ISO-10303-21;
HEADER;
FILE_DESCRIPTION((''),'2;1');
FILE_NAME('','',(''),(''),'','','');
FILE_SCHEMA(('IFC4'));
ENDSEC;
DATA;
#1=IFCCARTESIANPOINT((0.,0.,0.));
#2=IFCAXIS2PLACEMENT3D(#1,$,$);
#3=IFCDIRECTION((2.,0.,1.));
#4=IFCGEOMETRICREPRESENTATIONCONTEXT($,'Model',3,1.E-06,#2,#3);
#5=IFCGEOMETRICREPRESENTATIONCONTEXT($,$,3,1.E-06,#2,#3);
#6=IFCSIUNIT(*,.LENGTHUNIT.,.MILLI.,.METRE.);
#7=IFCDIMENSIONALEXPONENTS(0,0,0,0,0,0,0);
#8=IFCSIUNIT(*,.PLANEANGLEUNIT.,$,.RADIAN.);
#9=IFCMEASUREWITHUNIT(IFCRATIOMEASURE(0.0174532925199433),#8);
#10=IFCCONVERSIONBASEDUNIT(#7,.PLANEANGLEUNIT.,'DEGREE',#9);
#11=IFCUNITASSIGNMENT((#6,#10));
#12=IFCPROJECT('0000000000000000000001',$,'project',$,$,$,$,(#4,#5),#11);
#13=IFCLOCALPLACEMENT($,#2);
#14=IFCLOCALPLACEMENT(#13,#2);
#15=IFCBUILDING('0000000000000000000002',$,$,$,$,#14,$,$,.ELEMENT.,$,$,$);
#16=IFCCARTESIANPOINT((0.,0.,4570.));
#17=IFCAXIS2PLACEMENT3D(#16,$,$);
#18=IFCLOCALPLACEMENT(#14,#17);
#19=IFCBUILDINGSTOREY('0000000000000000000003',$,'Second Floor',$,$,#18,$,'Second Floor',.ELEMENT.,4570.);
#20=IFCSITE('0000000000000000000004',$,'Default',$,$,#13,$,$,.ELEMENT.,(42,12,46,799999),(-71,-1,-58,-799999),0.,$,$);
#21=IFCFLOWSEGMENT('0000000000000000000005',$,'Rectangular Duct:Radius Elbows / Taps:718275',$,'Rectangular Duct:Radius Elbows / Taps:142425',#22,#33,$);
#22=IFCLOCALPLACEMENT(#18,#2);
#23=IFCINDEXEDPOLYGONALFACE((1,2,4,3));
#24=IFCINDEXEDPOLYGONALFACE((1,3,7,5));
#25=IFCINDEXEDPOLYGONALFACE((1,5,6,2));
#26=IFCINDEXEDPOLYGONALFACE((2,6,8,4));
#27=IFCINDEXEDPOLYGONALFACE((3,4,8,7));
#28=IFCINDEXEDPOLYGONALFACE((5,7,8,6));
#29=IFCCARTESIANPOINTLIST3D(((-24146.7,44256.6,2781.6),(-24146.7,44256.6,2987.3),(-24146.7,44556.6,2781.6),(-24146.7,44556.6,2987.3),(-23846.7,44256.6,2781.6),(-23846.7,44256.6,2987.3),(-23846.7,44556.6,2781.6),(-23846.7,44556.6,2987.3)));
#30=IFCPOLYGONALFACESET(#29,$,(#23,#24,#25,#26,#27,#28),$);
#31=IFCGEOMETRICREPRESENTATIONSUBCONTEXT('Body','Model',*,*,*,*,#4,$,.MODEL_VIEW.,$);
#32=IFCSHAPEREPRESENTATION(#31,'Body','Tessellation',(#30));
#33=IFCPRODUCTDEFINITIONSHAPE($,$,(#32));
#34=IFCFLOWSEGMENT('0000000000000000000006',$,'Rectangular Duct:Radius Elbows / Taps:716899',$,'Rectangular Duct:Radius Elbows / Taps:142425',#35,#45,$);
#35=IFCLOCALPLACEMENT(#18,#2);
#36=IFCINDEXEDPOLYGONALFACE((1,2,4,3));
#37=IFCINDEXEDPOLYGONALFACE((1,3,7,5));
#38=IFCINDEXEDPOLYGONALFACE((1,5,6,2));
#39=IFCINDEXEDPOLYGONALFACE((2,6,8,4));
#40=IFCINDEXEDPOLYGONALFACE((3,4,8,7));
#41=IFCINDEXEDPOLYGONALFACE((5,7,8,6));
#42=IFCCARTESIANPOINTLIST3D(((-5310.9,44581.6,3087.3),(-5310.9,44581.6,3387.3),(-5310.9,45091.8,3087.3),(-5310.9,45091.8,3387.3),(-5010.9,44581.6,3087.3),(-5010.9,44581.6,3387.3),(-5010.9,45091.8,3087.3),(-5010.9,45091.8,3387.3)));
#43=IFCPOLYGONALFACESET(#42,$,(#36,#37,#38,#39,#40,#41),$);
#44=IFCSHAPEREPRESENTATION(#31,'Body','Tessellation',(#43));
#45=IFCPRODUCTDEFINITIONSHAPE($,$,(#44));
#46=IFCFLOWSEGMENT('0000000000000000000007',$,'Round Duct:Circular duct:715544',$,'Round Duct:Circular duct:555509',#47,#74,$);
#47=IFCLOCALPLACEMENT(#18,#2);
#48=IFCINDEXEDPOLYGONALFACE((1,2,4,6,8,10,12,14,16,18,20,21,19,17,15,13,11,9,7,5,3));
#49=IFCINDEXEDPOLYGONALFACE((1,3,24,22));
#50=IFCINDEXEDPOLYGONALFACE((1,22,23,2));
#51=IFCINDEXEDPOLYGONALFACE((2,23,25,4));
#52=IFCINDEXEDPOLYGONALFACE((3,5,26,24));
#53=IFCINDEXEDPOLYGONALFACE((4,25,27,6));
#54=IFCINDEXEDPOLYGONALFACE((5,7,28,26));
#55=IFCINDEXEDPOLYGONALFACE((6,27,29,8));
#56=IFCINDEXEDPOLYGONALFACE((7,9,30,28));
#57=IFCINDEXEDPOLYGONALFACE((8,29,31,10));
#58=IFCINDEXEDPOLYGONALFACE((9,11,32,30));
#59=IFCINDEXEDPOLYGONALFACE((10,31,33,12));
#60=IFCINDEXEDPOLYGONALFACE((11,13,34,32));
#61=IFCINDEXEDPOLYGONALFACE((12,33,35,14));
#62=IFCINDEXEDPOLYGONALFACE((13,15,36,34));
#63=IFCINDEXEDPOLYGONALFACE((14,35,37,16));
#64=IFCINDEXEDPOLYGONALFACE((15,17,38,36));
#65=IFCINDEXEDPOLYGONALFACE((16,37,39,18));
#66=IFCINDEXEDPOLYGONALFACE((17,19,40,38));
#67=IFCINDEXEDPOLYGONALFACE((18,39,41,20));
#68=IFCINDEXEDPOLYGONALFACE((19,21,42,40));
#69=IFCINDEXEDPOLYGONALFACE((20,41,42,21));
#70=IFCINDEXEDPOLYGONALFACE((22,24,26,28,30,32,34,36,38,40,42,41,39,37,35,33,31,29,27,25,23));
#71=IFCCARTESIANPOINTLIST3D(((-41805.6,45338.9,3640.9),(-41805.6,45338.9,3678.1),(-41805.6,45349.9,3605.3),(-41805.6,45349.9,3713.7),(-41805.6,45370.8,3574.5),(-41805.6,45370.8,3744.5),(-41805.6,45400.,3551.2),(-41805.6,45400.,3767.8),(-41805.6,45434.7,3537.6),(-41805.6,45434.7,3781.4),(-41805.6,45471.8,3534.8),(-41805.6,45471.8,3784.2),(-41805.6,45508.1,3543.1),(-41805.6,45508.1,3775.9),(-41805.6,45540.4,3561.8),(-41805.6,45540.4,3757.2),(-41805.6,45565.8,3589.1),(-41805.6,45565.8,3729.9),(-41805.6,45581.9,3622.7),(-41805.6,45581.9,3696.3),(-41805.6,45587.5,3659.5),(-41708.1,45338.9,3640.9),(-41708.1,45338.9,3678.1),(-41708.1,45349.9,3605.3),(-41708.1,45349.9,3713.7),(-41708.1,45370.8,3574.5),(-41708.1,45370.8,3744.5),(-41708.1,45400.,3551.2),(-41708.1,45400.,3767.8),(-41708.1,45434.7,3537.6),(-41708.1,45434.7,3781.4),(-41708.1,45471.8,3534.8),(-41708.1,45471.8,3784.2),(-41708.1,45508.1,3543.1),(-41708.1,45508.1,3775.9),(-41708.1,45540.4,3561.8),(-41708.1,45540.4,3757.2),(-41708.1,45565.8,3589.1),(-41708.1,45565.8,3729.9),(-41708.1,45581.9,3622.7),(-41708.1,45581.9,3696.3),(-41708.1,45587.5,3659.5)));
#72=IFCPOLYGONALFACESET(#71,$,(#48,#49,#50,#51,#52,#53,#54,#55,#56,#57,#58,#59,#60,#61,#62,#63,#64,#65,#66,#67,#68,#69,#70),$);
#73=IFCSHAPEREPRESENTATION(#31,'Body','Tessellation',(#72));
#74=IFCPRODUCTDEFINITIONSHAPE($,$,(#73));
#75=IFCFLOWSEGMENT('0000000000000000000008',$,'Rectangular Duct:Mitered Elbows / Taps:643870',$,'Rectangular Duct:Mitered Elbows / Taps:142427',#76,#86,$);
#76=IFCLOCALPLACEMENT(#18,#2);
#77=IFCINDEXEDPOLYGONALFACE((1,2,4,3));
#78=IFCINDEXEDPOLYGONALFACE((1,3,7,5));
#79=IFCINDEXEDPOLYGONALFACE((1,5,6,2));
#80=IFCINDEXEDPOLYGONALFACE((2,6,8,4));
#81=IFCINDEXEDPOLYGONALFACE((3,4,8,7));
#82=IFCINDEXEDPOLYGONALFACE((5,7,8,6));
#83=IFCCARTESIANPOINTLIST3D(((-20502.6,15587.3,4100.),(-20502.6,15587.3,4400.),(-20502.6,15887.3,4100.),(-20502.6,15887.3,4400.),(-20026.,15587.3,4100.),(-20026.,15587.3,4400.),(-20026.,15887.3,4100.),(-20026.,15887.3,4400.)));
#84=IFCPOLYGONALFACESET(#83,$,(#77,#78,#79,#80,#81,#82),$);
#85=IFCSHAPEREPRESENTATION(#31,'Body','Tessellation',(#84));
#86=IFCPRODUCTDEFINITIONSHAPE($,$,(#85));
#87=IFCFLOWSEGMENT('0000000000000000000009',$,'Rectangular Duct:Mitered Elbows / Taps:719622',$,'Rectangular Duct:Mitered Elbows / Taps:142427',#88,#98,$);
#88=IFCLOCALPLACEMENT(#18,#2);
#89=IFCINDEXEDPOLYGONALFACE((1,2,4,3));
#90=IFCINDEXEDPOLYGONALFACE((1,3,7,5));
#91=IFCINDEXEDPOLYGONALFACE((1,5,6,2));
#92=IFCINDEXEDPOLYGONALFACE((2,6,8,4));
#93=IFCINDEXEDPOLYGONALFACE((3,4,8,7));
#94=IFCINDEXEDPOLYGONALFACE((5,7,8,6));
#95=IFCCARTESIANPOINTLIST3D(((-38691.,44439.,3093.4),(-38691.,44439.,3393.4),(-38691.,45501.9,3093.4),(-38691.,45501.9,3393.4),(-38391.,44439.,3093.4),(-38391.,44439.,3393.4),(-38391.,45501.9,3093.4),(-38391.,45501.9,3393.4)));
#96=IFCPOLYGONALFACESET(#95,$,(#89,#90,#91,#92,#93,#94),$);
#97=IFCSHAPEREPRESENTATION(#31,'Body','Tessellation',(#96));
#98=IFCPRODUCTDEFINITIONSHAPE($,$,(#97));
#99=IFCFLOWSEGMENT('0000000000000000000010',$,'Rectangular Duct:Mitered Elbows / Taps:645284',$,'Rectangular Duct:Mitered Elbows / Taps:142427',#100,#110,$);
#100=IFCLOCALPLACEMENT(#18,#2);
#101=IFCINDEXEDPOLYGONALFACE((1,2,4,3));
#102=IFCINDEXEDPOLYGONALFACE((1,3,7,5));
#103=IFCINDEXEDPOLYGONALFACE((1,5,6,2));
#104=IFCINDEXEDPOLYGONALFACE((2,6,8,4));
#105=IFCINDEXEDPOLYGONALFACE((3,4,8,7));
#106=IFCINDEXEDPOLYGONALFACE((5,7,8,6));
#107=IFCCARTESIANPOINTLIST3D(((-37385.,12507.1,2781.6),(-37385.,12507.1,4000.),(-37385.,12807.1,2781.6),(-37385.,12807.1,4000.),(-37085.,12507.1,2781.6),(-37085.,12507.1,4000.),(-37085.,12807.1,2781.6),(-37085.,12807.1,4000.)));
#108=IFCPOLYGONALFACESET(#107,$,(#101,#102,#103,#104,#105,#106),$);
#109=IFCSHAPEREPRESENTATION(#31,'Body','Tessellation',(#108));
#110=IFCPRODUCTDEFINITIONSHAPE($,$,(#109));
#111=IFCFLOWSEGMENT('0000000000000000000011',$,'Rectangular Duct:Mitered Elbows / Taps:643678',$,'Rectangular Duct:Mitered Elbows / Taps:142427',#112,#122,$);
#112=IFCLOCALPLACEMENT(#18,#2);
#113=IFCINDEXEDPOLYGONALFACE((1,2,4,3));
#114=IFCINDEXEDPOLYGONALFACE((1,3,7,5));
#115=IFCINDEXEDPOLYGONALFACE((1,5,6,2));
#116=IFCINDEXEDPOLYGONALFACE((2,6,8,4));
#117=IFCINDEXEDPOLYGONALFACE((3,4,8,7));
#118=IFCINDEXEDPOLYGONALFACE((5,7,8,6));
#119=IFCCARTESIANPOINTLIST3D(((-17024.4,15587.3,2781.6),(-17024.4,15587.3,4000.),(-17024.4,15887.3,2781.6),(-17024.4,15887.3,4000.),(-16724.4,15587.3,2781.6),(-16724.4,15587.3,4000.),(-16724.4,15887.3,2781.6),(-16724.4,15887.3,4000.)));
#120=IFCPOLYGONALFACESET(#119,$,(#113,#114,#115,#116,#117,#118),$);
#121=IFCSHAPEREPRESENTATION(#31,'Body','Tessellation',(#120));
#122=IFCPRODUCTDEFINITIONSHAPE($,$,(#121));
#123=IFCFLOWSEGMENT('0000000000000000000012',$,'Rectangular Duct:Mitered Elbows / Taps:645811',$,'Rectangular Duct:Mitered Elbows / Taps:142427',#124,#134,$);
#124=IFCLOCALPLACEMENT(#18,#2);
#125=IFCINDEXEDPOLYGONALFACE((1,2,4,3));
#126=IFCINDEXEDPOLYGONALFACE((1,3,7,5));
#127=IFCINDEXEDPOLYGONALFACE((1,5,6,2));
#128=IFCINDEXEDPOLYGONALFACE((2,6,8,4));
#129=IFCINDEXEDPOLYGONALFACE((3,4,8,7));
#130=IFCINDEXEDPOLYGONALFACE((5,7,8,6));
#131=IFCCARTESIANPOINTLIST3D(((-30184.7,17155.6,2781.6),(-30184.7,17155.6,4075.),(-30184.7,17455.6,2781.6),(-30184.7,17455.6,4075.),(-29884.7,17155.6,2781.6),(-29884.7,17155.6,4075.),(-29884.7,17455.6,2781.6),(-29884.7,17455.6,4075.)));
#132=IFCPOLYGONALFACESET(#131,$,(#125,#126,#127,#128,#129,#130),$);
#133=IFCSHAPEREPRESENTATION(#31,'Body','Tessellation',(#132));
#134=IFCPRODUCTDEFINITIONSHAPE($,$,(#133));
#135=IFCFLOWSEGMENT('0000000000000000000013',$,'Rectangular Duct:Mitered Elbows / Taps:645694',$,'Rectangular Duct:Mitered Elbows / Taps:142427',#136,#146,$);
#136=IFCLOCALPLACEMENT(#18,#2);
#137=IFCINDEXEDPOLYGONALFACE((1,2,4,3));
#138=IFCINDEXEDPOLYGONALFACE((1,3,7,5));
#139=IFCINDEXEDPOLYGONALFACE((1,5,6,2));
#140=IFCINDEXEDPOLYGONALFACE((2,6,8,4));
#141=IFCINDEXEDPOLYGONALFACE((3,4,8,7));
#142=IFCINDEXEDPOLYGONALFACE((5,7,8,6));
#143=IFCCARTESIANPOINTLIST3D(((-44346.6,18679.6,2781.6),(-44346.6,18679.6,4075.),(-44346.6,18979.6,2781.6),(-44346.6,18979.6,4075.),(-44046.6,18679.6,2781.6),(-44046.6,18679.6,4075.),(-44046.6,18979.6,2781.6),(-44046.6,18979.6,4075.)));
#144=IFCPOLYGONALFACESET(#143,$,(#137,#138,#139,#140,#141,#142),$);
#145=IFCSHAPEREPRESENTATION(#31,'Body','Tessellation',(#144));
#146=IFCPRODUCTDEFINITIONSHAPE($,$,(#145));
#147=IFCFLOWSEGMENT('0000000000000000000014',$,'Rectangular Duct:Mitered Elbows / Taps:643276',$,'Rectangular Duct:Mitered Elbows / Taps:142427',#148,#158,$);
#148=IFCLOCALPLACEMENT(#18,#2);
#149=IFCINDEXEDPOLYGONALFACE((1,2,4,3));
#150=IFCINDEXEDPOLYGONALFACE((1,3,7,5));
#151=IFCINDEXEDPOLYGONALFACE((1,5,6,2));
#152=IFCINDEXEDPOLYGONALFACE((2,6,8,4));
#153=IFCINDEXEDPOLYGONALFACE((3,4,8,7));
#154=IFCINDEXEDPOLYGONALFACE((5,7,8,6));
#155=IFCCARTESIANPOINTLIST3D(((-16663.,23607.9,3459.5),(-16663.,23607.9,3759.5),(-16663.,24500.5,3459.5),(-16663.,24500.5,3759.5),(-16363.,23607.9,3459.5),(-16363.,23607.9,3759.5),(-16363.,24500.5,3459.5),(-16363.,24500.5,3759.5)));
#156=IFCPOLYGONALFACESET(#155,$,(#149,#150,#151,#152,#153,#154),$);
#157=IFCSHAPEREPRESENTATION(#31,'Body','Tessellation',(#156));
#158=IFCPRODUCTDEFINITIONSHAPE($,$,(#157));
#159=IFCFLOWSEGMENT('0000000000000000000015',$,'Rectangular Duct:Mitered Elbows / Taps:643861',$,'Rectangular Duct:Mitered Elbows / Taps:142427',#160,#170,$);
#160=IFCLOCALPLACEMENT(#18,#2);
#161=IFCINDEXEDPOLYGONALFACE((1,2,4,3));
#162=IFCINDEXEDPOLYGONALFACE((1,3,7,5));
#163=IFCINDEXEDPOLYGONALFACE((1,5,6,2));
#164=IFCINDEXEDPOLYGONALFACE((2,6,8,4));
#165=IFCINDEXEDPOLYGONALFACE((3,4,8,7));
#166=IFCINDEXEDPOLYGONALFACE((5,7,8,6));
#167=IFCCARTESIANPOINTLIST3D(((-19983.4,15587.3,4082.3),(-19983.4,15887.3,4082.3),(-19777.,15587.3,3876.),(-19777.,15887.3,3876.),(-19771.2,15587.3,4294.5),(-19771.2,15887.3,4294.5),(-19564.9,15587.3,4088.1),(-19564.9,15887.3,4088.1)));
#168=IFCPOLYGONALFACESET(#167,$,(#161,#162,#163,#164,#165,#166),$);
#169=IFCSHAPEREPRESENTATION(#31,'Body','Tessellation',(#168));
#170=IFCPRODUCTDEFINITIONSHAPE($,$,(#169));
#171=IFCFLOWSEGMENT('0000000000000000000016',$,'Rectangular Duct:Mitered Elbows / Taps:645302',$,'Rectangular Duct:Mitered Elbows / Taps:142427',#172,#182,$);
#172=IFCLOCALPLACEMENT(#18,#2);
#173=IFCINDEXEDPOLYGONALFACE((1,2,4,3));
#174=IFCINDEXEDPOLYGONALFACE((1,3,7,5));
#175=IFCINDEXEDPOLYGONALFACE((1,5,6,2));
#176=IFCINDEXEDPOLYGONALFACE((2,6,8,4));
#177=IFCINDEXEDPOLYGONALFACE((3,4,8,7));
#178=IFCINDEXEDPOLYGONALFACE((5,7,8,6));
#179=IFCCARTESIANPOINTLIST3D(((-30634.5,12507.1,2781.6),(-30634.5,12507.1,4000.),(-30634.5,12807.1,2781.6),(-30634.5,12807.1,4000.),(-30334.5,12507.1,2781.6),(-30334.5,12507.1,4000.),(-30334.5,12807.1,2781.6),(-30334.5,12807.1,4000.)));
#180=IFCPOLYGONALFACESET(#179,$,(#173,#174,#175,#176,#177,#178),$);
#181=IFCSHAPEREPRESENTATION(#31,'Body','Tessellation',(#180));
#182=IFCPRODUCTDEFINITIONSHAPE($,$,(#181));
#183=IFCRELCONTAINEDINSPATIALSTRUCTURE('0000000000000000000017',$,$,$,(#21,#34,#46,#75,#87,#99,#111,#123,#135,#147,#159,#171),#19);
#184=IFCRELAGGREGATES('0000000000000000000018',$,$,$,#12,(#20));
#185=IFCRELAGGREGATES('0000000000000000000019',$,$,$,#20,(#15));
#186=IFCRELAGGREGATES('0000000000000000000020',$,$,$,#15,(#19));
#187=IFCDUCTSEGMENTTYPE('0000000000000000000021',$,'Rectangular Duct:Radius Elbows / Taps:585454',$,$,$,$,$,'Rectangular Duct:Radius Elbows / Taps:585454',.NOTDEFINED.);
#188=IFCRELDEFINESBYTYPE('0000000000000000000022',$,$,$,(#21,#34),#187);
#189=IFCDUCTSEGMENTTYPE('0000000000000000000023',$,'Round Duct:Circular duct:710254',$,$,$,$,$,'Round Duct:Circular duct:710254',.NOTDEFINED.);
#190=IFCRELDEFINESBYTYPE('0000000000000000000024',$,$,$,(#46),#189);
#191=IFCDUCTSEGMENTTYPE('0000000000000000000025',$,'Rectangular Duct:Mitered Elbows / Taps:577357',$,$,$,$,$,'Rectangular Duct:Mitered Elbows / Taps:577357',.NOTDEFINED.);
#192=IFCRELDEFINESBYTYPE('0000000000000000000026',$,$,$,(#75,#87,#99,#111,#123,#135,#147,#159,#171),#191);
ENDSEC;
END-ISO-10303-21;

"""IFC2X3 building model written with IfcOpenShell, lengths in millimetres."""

from ifc_helpers import new_model, entity, si_unit, converted_unit, direction, frame, frame_2d, origin, origin_2d_with_axis, place, context, subcontext, project, spatial, rectangle, circle, extrude, type_object, element, save


model = new_model("IFC2X3")

# Units and contexts
model_context = context("Model", 3, precision=1e-06, world=origin(), true_north=direction((2.0, 0.0, 1.0)))
context_of_model = context(None, 3, precision=1e-06, world=origin(), true_north=direction((2.0, 0.0, 1.0)))
body_context = subcontext(model_context, "Body", "Model", "MODEL_VIEW")
ifc_project = project(units=[si_unit("LENGTHUNIT", "METRE", prefix="MILLI"), converted_unit("PLANEANGLEUNIT", "DEGREE", entity("IfcRatioMeasure", 0.0174532925199433), si_unit("PLANEANGLEUNIT", "RADIAN"), dimensions=[0, 0, 0, 0, 0, 0, 0])], contexts=[model_context, context_of_model])

# Site, building, storey
site_placement = place(None, origin())
site = spatial("IfcSite", under=ifc_project, at=site_placement, Name="Default", CompositionType="ELEMENT", RefLatitude=(42, 12, 46, 799999), RefLongitude=(-71, -1, -58, -799999), RefElevation=0.0)
building_placement = place(site_placement, origin())
building = spatial("IfcBuilding", under=site, at=building_placement, CompositionType="ELEMENT")
storey_placement = place(building_placement, frame((0.0, 0.0, 4570.0)))
storey = spatial("IfcBuildingStorey", under=building, at=storey_placement, Name="Second Floor", LongName="Second Floor", CompositionType="ELEMENT", Elevation=4570.0)

# Flow segments
duct_segment_type_1 = type_object("IfcDuctSegmentType", Name="Rectangular Duct:Radius Elbows / Taps:585454", ElementType="Rectangular Duct:Radius Elbows / Taps:585454", PredefinedType="NOTDEFINED")
flow_segment_1_placement = place(storey_placement, origin())
element("IfcFlowSegment", 1, at=flow_segment_1_placement, inside=storey, type_object=duct_segment_type_1, Name="Rectangular Duct:Radius Elbows / Taps:718275", ObjectType="Rectangular Duct:Radius Elbows / Taps:142425", context=body_context, shape_type="SweptSolid", body=[
    extrude(rectangle(XDim=300.0, YDim=300.0, at=origin_2d_with_axis()), frame((-23996.7, 44406.6, 2781.6), z_axis=(0.0, 0.0, 1.0), x_axis=(-1.0, 0.0, 0.0)), (0.0, 0.0, 1.0), 205.7),
])
flow_segment_2_placement = place(storey_placement, origin())
element("IfcFlowSegment", 2, at=flow_segment_2_placement, inside=storey, type_object=duct_segment_type_1, Name="Rectangular Duct:Radius Elbows / Taps:716899", ObjectType="Rectangular Duct:Radius Elbows / Taps:142425", context=body_context, shape_type="SweptSolid", body=[
    extrude(rectangle(XDim=510.1, YDim=300.0, at=frame_2d((0.0, 0.0), x_axis=(1.0, 0.0))), frame((-5160.9, 44836.7, 3087.3), z_axis=(0.0, 0.0, 1.0), x_axis=(0.0, -1.0, 0.0)), (0.0, 0.0, 1.0), 300.0),
])
duct_segment_type_2 = type_object("IfcDuctSegmentType", Name="Round Duct:Circular duct:710254", ElementType="Round Duct:Circular duct:710254", PredefinedType="NOTDEFINED")
flow_segment_3_placement = place(storey_placement, origin())
element("IfcFlowSegment", 3, at=flow_segment_3_placement, inside=storey, type_object=duct_segment_type_2, Name="Round Duct:Circular duct:715544", ObjectType="Round Duct:Circular duct:555509", context=body_context, shape_type="SweptSolid", body=[
    extrude(circle(Radius=125.0, at=origin_2d_with_axis()), frame((-41805.6, 45462.5, 3659.5), z_axis=(1.0, 0.0, 0.0), x_axis=(0.0, 1.0, 0.0)), (0.0, 0.0, 1.0), 97.5),
])
duct_segment_type_3 = type_object("IfcDuctSegmentType", Name="Rectangular Duct:Mitered Elbows / Taps:577357", ElementType="Rectangular Duct:Mitered Elbows / Taps:577357", PredefinedType="NOTDEFINED")
flow_segment_4_placement = place(storey_placement, origin())
element("IfcFlowSegment", 4, at=flow_segment_4_placement, inside=storey, type_object=duct_segment_type_3, Name="Rectangular Duct:Mitered Elbows / Taps:643870", ObjectType="Rectangular Duct:Mitered Elbows / Taps:142427", context=body_context, shape_type="SweptSolid", body=[
    extrude(rectangle(XDim=476.6, YDim=300.0, at=frame_2d((0.0, 0.0), x_axis=(1.0, 0.0))), frame((-20264.3, 15737.3, 4100.0), z_axis=(0.0, 0.0, 1.0), x_axis=(-1.0, 0.0, 0.0)), (0.0, 0.0, 1.0), 300.0),
])
flow_segment_5_placement = place(storey_placement, origin())
element("IfcFlowSegment", 5, at=flow_segment_5_placement, inside=storey, type_object=duct_segment_type_3, Name="Rectangular Duct:Mitered Elbows / Taps:719622", ObjectType="Rectangular Duct:Mitered Elbows / Taps:142427", context=body_context, shape_type="SweptSolid", body=[
    extrude(rectangle(XDim=1062.8, YDim=300.0, at=frame_2d((0.0, 0.0), x_axis=(1.0, 0.0))), frame((-38541.0, 44970.5, 3093.4), z_axis=(0.0, 0.0, 1.0), x_axis=(0.0, 1.0, 0.0)), (0.0, 0.0, 1.0), 300.0),
])
flow_segment_6_placement = place(storey_placement, origin())
element("IfcFlowSegment", 6, at=flow_segment_6_placement, inside=storey, type_object=duct_segment_type_3, Name="Rectangular Duct:Mitered Elbows / Taps:645284", ObjectType="Rectangular Duct:Mitered Elbows / Taps:142427", context=body_context, shape_type="SweptSolid", body=[
    extrude(rectangle(XDim=300.0, YDim=300.0, at=origin_2d_with_axis()), frame((-37235.0, 12657.1, 2781.6)), (0.0, 0.0, 1.0), 1218.4),
])
flow_segment_7_placement = place(storey_placement, origin())
element("IfcFlowSegment", 7, at=flow_segment_7_placement, inside=storey, type_object=duct_segment_type_3, Name="Rectangular Duct:Mitered Elbows / Taps:643678", ObjectType="Rectangular Duct:Mitered Elbows / Taps:142427", context=body_context, shape_type="SweptSolid", body=[
    extrude(rectangle(XDim=300.0, YDim=300.0, at=origin_2d_with_axis()), frame((-16874.4, 15737.3, 2781.6)), (0.0, 0.0, 1.0), 1218.4),
])
flow_segment_8_placement = place(storey_placement, origin())
element("IfcFlowSegment", 8, at=flow_segment_8_placement, inside=storey, type_object=duct_segment_type_3, Name="Rectangular Duct:Mitered Elbows / Taps:645811", ObjectType="Rectangular Duct:Mitered Elbows / Taps:142427", context=body_context, shape_type="SweptSolid", body=[
    extrude(rectangle(XDim=300.0, YDim=300.0, at=frame_2d((0.0, 0.0), x_axis=(1.0, 0.0))), frame((-30034.7, 17305.6, 2781.6)), (0.0, 0.0, 1.0), 1293.4),
])
flow_segment_9_placement = place(storey_placement, origin())
element("IfcFlowSegment", 9, at=flow_segment_9_placement, inside=storey, type_object=duct_segment_type_3, Name="Rectangular Duct:Mitered Elbows / Taps:645694", ObjectType="Rectangular Duct:Mitered Elbows / Taps:142427", context=body_context, shape_type="SweptSolid", body=[
    extrude(rectangle(XDim=300.0, YDim=300.0, at=origin_2d_with_axis()), frame((-44196.6, 18829.6, 2781.6), z_axis=(0.0, 0.0, 1.0), x_axis=(-1.0, 0.0, 0.0)), (0.0, 0.0, 1.0), 1293.4),
])
flow_segment_10_placement = place(storey_placement, origin())
element("IfcFlowSegment", 10, at=flow_segment_10_placement, inside=storey, type_object=duct_segment_type_3, Name="Rectangular Duct:Mitered Elbows / Taps:643276", ObjectType="Rectangular Duct:Mitered Elbows / Taps:142427", context=body_context, shape_type="SweptSolid", body=[
    extrude(rectangle(XDim=892.6, YDim=300.0, at=origin_2d_with_axis()), frame((-16513.0, 24054.2, 3459.5), z_axis=(0.0, 0.0, 1.0), x_axis=(0.0, 1.0, 0.0)), (0.0, 0.0, 1.0), 300.0),
])
flow_segment_11_placement = place(storey_placement, origin())
element("IfcFlowSegment", 11, at=flow_segment_11_placement, inside=storey, type_object=duct_segment_type_3, Name="Rectangular Duct:Mitered Elbows / Taps:643861", ObjectType="Rectangular Duct:Mitered Elbows / Taps:142427", context=body_context, shape_type="SweptSolid", body=[
    extrude(rectangle(XDim=291.8, YDim=300.0, at=frame_2d((0.0, 0.0), x_axis=(1.0, 0.0))), frame((-19774.1, 15587.3, 4085.2), z_axis=(0.0, 1.0, 0.0), x_axis=(-0.707107, 0.0, 0.707107)), (0.0, 0.0, 1.0), 300.0),
])
flow_segment_12_placement = place(storey_placement, origin())
element("IfcFlowSegment", 12, at=flow_segment_12_placement, inside=storey, type_object=duct_segment_type_3, Name="Rectangular Duct:Mitered Elbows / Taps:645302", ObjectType="Rectangular Duct:Mitered Elbows / Taps:142427", context=body_context, shape_type="SweptSolid", body=[
    extrude(rectangle(XDim=300.0, YDim=300.0, at=origin_2d_with_axis()), frame((-30484.5, 12657.1, 2781.6)), (0.0, 0.0, 1.0), 1218.4),
])

save(model, "model.ifc")
